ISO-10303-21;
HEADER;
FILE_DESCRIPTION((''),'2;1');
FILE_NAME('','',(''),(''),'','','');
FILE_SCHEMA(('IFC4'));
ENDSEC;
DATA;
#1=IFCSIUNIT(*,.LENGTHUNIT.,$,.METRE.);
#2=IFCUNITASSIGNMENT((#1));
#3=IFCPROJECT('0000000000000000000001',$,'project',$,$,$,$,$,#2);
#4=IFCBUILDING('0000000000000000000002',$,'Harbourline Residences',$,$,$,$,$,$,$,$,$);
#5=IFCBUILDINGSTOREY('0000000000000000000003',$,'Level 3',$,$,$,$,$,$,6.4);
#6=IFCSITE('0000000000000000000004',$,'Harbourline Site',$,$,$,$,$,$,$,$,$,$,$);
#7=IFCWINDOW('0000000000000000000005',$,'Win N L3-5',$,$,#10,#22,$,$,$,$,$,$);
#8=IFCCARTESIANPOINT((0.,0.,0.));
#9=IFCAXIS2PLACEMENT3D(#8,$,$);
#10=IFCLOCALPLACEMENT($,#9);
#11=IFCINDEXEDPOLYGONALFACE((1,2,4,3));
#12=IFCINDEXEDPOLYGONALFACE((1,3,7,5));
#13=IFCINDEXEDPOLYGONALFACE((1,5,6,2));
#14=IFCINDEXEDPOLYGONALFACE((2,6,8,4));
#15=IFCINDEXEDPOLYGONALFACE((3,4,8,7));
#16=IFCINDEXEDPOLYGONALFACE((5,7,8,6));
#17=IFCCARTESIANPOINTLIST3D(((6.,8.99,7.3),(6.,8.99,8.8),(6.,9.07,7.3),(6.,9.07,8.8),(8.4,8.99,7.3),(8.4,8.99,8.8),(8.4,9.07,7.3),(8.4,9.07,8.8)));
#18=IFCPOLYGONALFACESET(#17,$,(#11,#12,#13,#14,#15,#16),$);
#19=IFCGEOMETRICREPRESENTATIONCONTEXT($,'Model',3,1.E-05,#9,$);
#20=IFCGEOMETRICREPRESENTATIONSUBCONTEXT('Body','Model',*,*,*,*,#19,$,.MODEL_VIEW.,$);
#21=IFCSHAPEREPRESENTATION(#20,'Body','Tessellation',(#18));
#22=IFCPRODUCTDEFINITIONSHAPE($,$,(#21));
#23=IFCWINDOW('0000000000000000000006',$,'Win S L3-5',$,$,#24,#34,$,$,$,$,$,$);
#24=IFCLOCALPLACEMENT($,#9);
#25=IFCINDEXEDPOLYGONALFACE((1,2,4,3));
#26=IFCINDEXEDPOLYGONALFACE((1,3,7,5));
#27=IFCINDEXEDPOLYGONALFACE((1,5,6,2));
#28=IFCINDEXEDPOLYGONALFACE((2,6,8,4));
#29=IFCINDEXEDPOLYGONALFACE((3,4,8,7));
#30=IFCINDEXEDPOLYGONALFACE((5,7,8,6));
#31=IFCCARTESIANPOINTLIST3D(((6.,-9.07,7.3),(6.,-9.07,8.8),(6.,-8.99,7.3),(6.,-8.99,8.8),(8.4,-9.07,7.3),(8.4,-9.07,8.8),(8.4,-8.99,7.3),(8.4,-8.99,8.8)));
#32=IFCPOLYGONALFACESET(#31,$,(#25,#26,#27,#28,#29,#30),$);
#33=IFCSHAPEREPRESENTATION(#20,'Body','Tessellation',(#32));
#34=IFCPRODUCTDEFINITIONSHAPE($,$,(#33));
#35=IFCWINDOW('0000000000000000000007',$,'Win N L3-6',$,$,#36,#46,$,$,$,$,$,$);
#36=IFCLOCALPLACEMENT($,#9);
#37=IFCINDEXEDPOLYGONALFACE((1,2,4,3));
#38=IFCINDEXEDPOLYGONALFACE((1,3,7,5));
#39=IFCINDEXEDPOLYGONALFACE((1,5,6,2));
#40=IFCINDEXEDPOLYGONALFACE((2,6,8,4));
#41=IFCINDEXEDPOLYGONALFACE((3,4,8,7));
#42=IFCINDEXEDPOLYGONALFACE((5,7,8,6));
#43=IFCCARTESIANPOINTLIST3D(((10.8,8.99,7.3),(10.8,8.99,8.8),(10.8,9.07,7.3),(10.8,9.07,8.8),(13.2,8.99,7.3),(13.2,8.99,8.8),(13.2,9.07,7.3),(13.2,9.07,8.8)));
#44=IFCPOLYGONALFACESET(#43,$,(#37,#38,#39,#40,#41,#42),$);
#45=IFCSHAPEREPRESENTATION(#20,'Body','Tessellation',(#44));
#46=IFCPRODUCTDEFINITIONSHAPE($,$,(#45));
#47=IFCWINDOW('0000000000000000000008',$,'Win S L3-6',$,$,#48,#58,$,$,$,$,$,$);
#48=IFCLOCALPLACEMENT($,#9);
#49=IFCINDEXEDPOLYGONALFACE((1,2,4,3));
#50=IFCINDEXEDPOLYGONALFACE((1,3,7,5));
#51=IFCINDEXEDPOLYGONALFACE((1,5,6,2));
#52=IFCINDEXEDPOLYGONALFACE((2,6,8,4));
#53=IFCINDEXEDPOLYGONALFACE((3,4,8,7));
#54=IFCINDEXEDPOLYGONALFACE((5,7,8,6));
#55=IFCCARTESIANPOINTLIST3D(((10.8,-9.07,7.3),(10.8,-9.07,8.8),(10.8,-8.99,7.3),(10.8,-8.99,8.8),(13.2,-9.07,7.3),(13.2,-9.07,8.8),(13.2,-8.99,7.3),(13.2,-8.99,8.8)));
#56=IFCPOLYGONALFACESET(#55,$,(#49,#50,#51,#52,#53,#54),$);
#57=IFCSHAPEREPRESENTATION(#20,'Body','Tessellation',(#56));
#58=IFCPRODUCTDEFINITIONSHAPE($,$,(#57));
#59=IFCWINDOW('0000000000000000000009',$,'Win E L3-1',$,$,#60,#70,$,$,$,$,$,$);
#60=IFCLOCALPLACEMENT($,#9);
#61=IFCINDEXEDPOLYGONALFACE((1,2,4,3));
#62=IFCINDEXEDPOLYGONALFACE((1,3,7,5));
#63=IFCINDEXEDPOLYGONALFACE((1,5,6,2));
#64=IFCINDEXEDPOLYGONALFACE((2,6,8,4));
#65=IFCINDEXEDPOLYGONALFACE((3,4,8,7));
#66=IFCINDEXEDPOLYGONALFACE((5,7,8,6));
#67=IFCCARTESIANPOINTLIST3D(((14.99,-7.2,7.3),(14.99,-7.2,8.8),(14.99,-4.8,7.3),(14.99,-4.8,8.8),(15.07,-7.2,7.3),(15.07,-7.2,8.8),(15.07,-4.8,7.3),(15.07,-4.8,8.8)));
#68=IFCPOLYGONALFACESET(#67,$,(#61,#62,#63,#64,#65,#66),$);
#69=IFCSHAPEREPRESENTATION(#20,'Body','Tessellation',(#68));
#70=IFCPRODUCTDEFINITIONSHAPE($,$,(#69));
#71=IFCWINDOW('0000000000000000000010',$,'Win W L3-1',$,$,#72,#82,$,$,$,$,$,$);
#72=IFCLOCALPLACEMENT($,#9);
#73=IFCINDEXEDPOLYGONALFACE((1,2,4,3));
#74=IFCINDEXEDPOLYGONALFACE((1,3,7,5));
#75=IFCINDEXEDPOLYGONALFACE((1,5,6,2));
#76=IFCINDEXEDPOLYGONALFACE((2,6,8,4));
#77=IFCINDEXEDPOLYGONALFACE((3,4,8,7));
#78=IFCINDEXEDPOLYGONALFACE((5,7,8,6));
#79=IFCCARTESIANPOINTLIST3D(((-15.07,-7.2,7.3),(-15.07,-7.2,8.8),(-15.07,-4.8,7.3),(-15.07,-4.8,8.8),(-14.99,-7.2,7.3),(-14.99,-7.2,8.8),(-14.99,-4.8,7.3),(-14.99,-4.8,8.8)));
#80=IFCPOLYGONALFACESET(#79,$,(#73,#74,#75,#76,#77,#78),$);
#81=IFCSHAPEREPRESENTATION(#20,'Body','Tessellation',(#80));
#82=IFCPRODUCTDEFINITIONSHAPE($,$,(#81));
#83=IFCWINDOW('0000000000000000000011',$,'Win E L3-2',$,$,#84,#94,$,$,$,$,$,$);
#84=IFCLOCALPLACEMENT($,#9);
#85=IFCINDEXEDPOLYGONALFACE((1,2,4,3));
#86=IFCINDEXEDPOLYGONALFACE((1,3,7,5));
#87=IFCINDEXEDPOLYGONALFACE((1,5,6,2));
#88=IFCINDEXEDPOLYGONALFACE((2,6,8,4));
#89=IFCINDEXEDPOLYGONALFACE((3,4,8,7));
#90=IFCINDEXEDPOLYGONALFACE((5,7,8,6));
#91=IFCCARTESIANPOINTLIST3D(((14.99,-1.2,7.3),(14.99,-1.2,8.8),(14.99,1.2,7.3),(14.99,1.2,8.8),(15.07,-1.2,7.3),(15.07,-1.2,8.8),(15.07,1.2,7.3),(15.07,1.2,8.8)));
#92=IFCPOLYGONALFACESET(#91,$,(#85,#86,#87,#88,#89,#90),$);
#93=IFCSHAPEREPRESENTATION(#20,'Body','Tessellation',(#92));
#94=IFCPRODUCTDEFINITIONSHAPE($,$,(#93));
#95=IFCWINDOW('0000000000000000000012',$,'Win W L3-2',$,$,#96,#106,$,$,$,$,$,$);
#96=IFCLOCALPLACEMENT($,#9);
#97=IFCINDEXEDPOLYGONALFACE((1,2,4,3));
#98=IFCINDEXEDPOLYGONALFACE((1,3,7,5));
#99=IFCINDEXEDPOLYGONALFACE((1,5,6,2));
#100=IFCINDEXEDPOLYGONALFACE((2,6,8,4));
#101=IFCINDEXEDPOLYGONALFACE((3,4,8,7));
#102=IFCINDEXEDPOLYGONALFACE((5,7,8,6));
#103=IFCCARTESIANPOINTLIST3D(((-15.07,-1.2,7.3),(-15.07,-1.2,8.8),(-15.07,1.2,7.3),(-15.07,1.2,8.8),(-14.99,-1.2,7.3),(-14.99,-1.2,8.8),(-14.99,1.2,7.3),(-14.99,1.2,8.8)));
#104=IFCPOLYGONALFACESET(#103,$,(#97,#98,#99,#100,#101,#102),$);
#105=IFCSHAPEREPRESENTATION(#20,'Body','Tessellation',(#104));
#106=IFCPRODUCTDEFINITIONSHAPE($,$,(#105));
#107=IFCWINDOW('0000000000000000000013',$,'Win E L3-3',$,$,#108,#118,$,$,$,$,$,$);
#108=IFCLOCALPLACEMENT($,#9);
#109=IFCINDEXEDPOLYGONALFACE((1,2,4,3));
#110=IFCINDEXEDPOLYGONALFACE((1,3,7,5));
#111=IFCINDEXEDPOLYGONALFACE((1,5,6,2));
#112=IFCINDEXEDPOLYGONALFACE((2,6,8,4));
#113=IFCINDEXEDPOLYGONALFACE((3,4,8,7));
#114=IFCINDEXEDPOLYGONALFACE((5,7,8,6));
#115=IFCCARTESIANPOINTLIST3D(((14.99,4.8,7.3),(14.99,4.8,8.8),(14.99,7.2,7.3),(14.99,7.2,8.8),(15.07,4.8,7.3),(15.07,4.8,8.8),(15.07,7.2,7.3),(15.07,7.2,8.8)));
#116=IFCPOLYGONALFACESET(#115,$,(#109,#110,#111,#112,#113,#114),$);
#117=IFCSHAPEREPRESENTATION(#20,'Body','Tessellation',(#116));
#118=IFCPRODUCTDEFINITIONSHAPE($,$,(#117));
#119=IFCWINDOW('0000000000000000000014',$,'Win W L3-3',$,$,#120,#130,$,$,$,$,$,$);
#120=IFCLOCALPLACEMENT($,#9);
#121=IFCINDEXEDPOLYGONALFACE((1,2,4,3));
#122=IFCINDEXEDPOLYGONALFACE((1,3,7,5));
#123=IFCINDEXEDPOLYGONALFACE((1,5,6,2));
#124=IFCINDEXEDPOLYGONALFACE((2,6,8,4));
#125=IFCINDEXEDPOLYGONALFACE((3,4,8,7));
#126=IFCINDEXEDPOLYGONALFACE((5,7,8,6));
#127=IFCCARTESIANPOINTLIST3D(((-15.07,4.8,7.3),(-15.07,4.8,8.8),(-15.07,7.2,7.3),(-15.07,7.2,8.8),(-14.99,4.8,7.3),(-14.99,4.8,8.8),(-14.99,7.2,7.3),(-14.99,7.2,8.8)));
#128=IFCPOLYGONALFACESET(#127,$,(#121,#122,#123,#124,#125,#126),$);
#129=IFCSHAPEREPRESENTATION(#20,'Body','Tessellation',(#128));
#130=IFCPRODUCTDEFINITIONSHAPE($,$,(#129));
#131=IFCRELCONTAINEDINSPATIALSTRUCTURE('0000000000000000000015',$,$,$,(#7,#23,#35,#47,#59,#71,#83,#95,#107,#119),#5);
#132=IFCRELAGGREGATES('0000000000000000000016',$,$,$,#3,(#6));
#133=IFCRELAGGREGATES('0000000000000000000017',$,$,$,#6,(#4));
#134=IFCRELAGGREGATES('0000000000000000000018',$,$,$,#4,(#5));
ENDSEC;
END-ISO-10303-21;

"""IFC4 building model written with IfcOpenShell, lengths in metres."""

from ifc_helpers import new_model, si_unit, frame, frame_2d, origin, context, subcontext, project, spatial, rectangle, extrude, element, save


model = new_model("IFC4")

# Units and contexts
model_context = context("Model", 3, precision=1e-05, world=origin())
body_context = subcontext(model_context, "Body", "Model", "MODEL_VIEW")
ifc_project = project(units=[si_unit("LENGTHUNIT", "METRE")])

# Site, building, storey
site = spatial("IfcSite", under=ifc_project, Name="Harbourline Site")
building = spatial("IfcBuilding", under=site, Name="Harbourline Residences")
storey = spatial("IfcBuildingStorey", under=building, Name="Level 3", Elevation=6.4)

# Windows
element("IfcWindow", 1, inside=storey, Name="Win N L3-5", context=body_context, shape_type="SweptSolid", body=[
    extrude(rectangle(XDim=2.4, YDim=0.08, at=frame_2d((7.2, 9.03))), frame((0.0, 0.0, 7.3)), (0.0, 0.0, 1.0), 1.5),
])
element("IfcWindow", 2, inside=storey, Name="Win S L3-5", context=body_context, shape_type="SweptSolid", body=[
    extrude(rectangle(XDim=2.4, YDim=0.08, at=frame_2d((7.2, -9.03))), frame((0.0, 0.0, 7.3)), (0.0, 0.0, 1.0), 1.5),
])
element("IfcWindow", 3, inside=storey, Name="Win N L3-6", context=body_context, shape_type="SweptSolid", body=[
    extrude(rectangle(XDim=2.4, YDim=0.08, at=frame_2d((12.0, 9.03))), frame((0.0, 0.0, 7.3)), (0.0, 0.0, 1.0), 1.5),
])
element("IfcWindow", 4, inside=storey, Name="Win S L3-6", context=body_context, shape_type="SweptSolid", body=[
    extrude(rectangle(XDim=2.4, YDim=0.08, at=frame_2d((12.0, -9.03))), frame((0.0, 0.0, 7.3)), (0.0, 0.0, 1.0), 1.5),
])
element("IfcWindow", 5, inside=storey, Name="Win E L3-1", context=body_context, shape_type="SweptSolid", body=[
    extrude(rectangle(XDim=0.08, YDim=2.4, at=frame_2d((15.03, -6.0))), frame((0.0, 0.0, 7.3)), (0.0, 0.0, 1.0), 1.5),
])
element("IfcWindow", 6, inside=storey, Name="Win W L3-1", context=body_context, shape_type="SweptSolid", body=[
    extrude(rectangle(XDim=0.08, YDim=2.4, at=frame_2d((-15.03, -6.0))), frame((0.0, 0.0, 7.3)), (0.0, 0.0, 1.0), 1.5),
])
element("IfcWindow", 7, inside=storey, Name="Win E L3-2", context=body_context, shape_type="SweptSolid", body=[
    extrude(rectangle(XDim=0.08, YDim=2.4, at=frame_2d((15.03, 0.0))), frame((0.0, 0.0, 7.3)), (0.0, 0.0, 1.0), 1.5),
])
element("IfcWindow", 8, inside=storey, Name="Win W L3-2", context=body_context, shape_type="SweptSolid", body=[
    extrude(rectangle(XDim=0.08, YDim=2.4, at=frame_2d((-15.03, 0.0))), frame((0.0, 0.0, 7.3)), (0.0, 0.0, 1.0), 1.5),
])
element("IfcWindow", 9, inside=storey, Name="Win E L3-3", context=body_context, shape_type="SweptSolid", body=[
    extrude(rectangle(XDim=0.08, YDim=2.4, at=frame_2d((15.03, 6.0))), frame((0.0, 0.0, 7.3)), (0.0, 0.0, 1.0), 1.5),
])
element("IfcWindow", 10, inside=storey, Name="Win W L3-3", context=body_context, shape_type="SweptSolid", body=[
    extrude(rectangle(XDim=0.08, YDim=2.4, at=frame_2d((-15.03, 6.0))), frame((0.0, 0.0, 7.3)), (0.0, 0.0, 1.0), 1.5),
])

save(model, "model.ifc")
